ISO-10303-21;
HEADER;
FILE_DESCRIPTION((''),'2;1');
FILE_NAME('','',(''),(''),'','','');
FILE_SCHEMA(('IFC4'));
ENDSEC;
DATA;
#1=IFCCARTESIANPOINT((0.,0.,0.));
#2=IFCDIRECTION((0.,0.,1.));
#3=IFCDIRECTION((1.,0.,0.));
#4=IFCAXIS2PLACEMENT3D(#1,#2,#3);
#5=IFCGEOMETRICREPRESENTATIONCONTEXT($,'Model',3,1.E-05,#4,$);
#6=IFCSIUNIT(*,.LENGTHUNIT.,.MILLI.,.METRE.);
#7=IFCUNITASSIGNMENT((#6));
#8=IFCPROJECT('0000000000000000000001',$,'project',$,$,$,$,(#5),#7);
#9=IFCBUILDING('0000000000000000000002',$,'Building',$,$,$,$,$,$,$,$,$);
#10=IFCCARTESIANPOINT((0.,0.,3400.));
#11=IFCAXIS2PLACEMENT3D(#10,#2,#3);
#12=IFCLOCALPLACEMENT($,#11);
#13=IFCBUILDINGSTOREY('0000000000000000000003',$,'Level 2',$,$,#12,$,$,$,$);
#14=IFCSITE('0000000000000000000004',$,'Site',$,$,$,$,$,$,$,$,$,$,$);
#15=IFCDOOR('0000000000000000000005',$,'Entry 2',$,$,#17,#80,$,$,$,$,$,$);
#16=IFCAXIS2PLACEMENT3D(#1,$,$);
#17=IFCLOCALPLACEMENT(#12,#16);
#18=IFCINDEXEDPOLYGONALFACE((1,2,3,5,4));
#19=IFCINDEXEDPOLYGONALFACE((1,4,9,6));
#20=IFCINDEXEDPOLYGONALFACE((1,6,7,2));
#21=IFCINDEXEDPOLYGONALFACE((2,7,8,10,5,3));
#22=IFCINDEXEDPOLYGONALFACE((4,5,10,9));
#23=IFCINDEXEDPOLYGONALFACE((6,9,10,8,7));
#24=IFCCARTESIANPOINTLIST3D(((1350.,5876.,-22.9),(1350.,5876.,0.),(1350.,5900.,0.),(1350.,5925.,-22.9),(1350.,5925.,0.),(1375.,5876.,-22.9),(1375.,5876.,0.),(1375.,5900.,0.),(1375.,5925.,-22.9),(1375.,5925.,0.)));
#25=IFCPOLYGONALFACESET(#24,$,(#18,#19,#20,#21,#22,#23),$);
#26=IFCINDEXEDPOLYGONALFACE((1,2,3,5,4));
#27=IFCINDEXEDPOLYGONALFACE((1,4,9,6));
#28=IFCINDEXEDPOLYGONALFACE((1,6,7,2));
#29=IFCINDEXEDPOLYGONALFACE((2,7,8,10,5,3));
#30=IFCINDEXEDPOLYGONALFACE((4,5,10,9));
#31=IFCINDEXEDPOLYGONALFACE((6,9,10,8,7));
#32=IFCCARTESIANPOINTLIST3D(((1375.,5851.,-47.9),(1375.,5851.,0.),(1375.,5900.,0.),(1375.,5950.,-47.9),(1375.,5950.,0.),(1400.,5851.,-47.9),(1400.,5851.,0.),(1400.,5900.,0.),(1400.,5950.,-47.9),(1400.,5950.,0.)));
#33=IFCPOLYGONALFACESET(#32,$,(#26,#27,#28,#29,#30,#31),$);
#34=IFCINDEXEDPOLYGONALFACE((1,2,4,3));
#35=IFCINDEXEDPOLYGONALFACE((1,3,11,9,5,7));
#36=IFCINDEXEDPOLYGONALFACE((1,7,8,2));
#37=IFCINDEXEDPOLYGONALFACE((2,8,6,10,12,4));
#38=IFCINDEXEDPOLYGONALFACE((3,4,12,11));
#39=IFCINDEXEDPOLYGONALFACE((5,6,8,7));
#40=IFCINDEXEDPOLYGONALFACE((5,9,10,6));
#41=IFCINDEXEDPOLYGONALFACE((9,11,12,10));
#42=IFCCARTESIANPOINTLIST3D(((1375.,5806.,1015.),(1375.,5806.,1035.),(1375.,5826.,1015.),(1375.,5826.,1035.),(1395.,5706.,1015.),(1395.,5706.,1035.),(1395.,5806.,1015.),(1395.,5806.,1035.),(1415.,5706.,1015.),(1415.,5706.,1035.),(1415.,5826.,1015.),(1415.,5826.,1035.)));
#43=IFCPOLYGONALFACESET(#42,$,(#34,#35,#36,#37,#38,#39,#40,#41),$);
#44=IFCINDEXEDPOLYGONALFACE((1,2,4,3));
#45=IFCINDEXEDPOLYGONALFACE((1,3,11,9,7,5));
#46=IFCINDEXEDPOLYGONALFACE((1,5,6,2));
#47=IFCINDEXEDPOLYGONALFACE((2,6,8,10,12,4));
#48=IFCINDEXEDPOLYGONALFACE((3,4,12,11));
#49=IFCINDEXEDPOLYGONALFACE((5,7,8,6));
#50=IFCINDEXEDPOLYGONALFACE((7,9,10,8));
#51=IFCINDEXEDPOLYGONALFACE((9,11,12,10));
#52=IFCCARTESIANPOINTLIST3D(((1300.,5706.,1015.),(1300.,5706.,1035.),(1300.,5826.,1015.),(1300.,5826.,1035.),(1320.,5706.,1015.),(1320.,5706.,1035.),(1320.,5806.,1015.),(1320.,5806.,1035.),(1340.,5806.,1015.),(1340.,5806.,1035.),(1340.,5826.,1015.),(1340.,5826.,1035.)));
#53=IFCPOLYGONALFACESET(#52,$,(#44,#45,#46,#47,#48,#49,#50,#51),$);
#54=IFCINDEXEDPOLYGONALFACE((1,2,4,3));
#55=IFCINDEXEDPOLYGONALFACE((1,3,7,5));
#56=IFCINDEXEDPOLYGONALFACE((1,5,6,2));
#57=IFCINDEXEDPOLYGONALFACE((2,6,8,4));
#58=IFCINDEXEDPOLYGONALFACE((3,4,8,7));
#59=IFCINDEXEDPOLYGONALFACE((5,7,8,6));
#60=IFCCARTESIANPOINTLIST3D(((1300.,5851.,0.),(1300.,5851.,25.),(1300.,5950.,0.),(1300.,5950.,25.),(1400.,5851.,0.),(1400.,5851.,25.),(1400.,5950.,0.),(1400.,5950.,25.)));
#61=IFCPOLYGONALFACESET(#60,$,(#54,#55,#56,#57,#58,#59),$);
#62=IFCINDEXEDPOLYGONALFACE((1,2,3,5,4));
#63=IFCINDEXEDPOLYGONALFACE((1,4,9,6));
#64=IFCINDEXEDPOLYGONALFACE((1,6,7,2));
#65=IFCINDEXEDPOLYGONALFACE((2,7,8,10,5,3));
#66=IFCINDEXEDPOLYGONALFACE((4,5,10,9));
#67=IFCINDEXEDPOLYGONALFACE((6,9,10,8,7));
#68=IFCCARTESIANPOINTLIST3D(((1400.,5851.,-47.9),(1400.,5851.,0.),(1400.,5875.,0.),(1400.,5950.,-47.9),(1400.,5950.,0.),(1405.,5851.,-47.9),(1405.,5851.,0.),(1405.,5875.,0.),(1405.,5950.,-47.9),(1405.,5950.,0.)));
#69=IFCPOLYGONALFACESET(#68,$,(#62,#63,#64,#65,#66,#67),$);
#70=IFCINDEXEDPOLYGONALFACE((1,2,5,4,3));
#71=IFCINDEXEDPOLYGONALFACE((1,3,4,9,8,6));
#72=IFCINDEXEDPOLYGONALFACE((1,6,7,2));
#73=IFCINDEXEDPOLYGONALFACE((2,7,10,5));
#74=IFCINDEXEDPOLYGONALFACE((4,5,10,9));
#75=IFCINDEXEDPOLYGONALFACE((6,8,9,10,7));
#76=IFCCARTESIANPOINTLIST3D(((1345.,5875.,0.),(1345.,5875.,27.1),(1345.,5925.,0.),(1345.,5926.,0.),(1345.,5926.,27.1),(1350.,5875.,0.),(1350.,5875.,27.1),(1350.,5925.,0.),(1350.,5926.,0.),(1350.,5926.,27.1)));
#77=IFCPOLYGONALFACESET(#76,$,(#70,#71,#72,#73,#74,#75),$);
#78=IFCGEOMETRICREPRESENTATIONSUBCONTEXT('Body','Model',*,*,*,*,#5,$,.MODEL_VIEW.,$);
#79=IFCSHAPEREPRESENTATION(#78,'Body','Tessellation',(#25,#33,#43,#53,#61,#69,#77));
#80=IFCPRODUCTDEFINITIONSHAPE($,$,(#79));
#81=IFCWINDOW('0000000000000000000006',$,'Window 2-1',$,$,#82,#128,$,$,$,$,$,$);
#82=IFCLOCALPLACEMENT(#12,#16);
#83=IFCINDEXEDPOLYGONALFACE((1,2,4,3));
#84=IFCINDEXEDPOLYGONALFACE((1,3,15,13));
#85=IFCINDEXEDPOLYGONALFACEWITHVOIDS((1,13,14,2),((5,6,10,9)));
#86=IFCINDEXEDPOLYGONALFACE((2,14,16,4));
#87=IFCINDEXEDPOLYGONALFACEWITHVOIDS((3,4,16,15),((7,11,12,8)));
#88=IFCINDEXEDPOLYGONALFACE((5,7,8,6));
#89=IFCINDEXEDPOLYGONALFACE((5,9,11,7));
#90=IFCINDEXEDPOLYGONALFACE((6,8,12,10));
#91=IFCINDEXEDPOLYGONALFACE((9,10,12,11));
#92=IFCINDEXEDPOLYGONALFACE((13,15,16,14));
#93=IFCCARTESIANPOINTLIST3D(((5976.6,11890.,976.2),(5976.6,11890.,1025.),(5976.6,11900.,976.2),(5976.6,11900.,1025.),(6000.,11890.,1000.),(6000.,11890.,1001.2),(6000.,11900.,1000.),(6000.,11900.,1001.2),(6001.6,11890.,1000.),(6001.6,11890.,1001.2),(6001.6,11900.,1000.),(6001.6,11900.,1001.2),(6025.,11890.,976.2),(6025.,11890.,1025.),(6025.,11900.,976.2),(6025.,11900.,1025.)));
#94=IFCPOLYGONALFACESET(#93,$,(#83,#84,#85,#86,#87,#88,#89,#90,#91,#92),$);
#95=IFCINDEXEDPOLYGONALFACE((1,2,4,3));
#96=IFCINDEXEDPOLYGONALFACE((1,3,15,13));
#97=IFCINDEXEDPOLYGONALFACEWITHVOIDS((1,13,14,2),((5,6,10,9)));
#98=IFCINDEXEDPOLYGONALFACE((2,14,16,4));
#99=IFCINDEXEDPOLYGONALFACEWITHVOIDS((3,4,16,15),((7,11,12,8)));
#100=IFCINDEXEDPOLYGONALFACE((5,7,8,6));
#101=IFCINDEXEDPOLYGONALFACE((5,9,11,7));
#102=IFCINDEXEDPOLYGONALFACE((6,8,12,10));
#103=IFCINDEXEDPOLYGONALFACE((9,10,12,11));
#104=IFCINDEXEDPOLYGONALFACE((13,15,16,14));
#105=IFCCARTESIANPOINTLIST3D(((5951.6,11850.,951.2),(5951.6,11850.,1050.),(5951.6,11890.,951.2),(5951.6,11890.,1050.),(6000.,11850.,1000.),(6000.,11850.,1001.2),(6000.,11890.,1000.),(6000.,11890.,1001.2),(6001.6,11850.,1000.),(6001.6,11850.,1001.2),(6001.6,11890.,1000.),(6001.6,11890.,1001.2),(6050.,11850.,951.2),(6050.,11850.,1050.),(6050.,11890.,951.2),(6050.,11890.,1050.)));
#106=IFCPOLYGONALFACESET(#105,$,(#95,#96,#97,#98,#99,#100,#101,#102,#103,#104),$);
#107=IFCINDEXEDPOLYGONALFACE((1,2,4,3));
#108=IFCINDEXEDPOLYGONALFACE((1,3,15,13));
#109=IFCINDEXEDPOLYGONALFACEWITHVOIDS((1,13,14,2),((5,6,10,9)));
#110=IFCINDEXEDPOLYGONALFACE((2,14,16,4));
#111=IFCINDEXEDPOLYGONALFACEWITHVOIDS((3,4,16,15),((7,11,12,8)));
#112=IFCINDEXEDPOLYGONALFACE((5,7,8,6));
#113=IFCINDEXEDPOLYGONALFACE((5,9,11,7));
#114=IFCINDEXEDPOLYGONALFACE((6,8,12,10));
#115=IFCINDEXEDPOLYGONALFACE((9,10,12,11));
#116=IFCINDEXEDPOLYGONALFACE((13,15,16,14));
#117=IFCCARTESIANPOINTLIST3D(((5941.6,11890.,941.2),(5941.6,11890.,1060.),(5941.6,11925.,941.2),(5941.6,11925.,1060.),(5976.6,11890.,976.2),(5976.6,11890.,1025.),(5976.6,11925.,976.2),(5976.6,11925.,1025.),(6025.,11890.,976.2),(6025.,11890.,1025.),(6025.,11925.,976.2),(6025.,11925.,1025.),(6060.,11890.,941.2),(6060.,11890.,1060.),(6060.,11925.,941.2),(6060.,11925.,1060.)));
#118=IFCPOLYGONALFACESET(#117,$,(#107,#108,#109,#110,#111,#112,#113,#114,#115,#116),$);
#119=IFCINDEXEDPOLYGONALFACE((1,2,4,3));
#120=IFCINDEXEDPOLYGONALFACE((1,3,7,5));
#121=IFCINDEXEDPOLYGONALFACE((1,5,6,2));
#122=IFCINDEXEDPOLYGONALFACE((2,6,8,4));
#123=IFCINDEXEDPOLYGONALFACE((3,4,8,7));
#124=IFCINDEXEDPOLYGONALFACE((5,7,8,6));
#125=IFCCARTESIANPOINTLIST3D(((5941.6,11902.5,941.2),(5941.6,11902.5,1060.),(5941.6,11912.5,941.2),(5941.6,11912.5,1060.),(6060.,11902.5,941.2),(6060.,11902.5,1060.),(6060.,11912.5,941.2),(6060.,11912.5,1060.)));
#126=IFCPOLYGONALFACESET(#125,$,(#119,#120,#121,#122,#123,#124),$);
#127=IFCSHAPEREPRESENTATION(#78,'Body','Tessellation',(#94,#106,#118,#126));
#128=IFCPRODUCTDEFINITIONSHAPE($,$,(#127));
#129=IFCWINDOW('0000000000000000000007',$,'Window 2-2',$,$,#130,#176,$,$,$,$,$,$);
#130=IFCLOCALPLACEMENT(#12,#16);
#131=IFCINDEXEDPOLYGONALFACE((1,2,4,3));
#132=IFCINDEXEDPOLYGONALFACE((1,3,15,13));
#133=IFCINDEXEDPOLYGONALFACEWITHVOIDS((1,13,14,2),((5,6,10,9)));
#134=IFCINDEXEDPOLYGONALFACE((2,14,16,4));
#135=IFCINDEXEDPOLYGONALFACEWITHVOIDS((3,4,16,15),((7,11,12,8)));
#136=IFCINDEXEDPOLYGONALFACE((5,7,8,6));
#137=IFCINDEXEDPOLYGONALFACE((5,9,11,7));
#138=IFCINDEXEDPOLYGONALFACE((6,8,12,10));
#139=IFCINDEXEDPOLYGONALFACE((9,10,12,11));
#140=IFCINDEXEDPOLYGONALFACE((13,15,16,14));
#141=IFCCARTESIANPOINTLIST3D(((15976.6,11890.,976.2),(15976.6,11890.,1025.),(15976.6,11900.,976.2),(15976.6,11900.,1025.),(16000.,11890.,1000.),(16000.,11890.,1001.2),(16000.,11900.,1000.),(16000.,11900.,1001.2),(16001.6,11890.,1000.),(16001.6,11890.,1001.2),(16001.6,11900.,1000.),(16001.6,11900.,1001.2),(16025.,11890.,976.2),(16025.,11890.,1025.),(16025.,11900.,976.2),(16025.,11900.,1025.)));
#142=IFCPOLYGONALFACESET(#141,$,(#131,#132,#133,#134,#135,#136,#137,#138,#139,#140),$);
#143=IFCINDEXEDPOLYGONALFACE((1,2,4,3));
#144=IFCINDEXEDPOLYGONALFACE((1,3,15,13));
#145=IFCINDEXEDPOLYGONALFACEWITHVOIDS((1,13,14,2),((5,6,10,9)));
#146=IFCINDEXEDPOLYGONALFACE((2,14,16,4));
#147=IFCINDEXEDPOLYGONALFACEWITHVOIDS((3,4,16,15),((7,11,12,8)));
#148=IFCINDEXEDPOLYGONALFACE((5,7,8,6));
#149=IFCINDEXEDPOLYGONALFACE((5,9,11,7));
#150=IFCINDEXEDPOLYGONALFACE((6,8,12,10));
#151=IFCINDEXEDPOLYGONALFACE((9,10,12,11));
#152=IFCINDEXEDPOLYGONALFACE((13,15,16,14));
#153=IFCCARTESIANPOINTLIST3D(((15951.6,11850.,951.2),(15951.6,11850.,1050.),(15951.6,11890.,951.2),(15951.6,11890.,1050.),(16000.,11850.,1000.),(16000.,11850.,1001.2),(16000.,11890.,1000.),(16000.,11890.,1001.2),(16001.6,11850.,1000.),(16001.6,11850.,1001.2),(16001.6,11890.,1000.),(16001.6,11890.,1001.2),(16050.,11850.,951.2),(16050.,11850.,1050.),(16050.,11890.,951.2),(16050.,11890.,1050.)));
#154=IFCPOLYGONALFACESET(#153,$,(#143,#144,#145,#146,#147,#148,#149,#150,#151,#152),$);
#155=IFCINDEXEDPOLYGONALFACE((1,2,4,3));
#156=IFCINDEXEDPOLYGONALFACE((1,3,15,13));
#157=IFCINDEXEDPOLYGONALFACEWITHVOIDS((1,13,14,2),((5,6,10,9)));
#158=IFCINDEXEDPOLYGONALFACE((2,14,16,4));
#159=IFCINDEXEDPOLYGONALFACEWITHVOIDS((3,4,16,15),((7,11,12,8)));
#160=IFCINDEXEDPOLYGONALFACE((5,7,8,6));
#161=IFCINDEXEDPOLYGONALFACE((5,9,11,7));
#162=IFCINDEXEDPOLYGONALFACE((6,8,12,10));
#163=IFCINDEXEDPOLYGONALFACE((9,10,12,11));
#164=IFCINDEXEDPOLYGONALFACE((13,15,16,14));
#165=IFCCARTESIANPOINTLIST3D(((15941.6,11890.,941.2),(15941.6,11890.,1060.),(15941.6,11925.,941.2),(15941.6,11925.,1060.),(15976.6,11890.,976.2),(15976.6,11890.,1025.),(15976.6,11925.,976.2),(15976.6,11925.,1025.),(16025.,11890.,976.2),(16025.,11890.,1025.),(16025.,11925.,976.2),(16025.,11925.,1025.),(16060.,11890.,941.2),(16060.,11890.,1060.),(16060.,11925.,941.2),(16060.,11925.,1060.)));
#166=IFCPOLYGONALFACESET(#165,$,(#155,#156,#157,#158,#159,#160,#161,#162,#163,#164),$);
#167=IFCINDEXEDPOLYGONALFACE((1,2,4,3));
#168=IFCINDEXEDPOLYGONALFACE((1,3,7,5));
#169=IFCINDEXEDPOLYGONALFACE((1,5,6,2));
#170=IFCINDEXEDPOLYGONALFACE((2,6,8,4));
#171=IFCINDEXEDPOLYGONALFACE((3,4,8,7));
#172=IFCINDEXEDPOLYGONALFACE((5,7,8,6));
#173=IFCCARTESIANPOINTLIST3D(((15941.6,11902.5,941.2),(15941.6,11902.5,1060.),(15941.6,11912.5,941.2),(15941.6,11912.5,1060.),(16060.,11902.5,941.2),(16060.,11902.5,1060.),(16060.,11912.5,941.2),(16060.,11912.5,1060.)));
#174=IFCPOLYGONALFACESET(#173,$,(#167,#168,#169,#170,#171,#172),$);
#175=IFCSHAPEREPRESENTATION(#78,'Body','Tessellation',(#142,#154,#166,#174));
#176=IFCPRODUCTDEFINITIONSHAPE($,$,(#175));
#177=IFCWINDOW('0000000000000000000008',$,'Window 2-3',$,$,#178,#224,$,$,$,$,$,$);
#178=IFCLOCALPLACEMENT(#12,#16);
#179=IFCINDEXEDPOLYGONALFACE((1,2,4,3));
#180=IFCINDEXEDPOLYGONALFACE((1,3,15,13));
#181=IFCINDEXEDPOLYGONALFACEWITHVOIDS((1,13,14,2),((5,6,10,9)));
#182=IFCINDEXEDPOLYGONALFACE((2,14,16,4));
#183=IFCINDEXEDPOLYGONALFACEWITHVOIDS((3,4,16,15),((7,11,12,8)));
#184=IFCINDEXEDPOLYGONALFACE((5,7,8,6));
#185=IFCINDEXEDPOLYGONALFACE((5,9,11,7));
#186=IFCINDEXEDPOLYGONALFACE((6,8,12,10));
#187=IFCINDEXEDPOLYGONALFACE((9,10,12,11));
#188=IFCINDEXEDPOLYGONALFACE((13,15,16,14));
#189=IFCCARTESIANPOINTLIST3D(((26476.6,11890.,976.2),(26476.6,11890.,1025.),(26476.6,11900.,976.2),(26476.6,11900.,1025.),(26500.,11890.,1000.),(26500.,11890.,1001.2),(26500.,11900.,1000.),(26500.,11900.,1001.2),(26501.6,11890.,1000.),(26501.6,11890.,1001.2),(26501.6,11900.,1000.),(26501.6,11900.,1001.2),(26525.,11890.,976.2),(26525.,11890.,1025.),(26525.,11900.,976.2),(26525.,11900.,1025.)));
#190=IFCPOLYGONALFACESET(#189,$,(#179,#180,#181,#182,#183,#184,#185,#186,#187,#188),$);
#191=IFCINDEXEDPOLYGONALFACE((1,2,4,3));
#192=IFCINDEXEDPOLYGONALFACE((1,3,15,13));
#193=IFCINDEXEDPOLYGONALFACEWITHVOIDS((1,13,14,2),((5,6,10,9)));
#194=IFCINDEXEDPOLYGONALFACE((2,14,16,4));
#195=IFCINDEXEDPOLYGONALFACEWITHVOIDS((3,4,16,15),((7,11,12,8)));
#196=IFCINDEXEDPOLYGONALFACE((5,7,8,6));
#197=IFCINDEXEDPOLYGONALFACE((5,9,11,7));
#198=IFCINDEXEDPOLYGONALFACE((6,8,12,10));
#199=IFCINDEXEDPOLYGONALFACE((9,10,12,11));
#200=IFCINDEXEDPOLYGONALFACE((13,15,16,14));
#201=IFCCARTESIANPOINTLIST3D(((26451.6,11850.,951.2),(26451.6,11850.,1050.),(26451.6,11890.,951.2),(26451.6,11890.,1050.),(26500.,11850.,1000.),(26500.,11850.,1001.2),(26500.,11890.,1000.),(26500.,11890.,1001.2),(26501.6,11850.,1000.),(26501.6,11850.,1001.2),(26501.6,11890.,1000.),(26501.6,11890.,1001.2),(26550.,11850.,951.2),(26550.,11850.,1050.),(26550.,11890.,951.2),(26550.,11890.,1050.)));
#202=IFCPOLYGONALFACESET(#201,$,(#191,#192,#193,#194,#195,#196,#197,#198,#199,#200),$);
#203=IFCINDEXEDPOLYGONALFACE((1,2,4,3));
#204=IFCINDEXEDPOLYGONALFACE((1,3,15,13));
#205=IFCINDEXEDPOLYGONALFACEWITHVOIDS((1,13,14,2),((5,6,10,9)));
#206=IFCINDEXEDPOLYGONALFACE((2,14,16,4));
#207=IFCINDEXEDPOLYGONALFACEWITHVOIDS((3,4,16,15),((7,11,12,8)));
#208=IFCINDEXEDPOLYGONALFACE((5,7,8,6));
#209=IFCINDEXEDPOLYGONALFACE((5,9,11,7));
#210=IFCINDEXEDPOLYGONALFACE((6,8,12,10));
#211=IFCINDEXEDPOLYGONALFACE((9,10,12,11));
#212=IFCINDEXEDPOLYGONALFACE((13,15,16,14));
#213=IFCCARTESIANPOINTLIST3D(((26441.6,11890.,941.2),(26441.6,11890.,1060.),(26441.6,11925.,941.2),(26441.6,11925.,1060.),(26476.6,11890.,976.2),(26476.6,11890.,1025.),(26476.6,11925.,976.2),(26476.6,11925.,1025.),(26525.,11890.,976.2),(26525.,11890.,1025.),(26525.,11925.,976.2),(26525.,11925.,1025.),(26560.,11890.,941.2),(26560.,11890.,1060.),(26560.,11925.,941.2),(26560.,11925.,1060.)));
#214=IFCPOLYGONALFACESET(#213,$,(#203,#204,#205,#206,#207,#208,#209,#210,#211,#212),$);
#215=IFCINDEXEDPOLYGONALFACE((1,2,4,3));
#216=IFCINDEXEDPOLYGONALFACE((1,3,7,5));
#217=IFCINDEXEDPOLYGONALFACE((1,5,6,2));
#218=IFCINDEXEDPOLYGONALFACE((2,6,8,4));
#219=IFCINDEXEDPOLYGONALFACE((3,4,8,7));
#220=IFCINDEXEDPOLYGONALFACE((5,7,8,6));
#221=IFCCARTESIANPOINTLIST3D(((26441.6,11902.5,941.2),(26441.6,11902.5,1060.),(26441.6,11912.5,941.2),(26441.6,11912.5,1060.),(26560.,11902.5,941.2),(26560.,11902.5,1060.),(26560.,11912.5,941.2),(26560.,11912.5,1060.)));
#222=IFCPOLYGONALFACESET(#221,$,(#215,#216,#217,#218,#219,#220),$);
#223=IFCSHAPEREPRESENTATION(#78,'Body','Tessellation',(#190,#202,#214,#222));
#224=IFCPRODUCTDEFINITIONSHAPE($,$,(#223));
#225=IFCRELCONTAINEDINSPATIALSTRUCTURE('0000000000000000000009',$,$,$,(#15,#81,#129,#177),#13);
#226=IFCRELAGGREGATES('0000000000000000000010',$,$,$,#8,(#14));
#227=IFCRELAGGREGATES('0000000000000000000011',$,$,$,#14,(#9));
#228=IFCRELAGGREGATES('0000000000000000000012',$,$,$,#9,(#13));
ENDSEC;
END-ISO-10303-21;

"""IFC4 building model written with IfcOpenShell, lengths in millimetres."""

from ifc_helpers import new_model, si_unit, frame, origin_with_axes, place, context, subcontext, project, spatial, line, indexed_curve, outline, extrude, element, save


model = new_model("IFC4")

# Units and contexts
model_context = context("Model", 3, precision=1e-05, world=origin_with_axes())
body_context = subcontext(model_context, "Body", "Model", "MODEL_VIEW")
ifc_project = project(units=[si_unit("LENGTHUNIT", "METRE", prefix="MILLI")], contexts=[model_context])

# Site, building, storey
site = spatial("IfcSite", under=ifc_project, Name="Site")
building = spatial("IfcBuilding", under=site, Name="Building")
storey_placement = place(None, frame((0.0, 0.0, 3400.0), z_axis=(0.0, 0.0, 1.0), x_axis=(1.0, 0.0, 0.0)))
storey = spatial("IfcBuildingStorey", under=building, at=storey_placement, Name="Level 2")

# Door
door_1_placement = place(storey_placement, frame((1400.0, 5900.0, 0.0), z_axis=(0.0, 0.0, 1.0), x_axis=(0.0, 1.0, 0.0)))
element("IfcDoor", 1, at=door_1_placement, inside=storey, Name="Entry 2", context=body_context, shape_type="SweptSolid", body=[
    extrude(outline(indexed_curve([(0.0, 0.0), (0.0, 2.1), (1.0, 2.1), (1.0, 0.0), (-24.0, 0.0), (-24.0, -22.9), (25.0, -22.9), (25.0, 0.0)], segments=[line(1, 2, 3, 4, 5, 6, 7, 8, 1)])), frame((0.0, 25.0, 0.0), z_axis=(0.0, -1.0, 0.0), x_axis=(1.0, 0.0, 0.0)), (0.0, 0.0, -1.0), 25.0),
    extrude(outline(indexed_curve([(0.0, 0.0), (0.0, 2.1), (1.0, 2.1), (1.0, 0.0), (-49.0, 0.0), (-49.0, -47.9), (50.0, -47.9), (50.0, 0.0)], segments=[line(1, 2, 3, 4, 5, 6, 7, 8, 1)])), frame((0.0, 0.0, 0.0), z_axis=(0.0, -1.0, 0.0), x_axis=(1.0, 0.0, 0.0)), (0.0, 0.0, -1.0), 25.0),
    extrude(outline(indexed_curve([(0.0, 0.0), (-49.0, 0.0), (-49.0, 35.0), (0.0, 35.0)], segments=[line(1, 2, 3, 4, 1)])), frame((25.0, 25.0, 25.0), z_axis=(0.0, 0.0, 1.0), x_axis=(1.0, 0.0, 0.0)), (0.0, 0.0, 1.0), -47.9),
    extrude(outline(indexed_curve([(0.0, 0.0), (0.0, -40.0), (-120.0, -40.0), (-120.0, -20.0), (-20.0, -20.0), (-20.0, 0.0)], segments=[line(1, 2, 3, 4, 5, 6, 1)])), frame((-74.0, 25.0, 1015.0), z_axis=(0.0, 0.0, 1.0), x_axis=(1.0, 0.0, 0.0)), (0.0, 0.0, 1.0), 20.0),
    extrude(outline(indexed_curve([(0.0, 0.0), (0.0, 40.0), (-120.0, 40.0), (-120.0, 20.0), (-20.0, 20.0), (-20.0, 0.0)], segments=[line(1, 2, 3, 4, 5, 6, 1)])), frame((-74.0, 60.0, 1015.0), z_axis=(0.0, 0.0, 1.0), x_axis=(1.0, 0.0, 0.0)), (0.0, 0.0, 1.0), 20.0),
    extrude(outline(indexed_curve([(0.0, 0.0), (-99.0, 0.0), (-99.0, 100.0), (0.0, 100.0)], segments=[line(1, 2, 3, 4, 1)])), frame((50.0, 0.0, 0.0), z_axis=(0.0, 0.0, 1.0), x_axis=(1.0, 0.0, 0.0)), (0.0, 0.0, 1.0), 25.0),
    extrude(outline(indexed_curve([(0.0, 0.0), (0.0, 27.1), (51.0, 27.1), (51.0, 0.0), (-24.0, 0.0), (-24.0, -47.9), (75.0, -47.9), (75.0, 0.0)], segments=[line(1, 2, 3, 4, 5, 6, 7, 8, 1)])), frame((-25.0, -5.0, 0.0), z_axis=(0.0, -1.0, 0.0), x_axis=(1.0, 0.0, 0.0)), (0.0, 0.0, -1.0), 5.0),
    extrude(outline(indexed_curve([(0.0, 0.0), (0.0, 27.1), (51.0, 27.1), (51.0, 0.0), (1.0, 0.0), (1.0, -22.9), (50.0, -22.9), (50.0, 0.0)], segments=[line(1, 2, 3, 4, 5, 6, 7, 8, 1)])), frame((-25.0, 50.0, 0.0), z_axis=(0.0, -1.0, 0.0), x_axis=(1.0, 0.0, 0.0)), (0.0, 0.0, -1.0), 5.0),
])

# Windows
for number, where, z_axis, x_axis, name in (
    (2, (6000.0, 11800.0, 1000.0), (0.0, 0.0, 1.0), (1.0, 0.0, 0.0), "Window 2-1"),
    (3, (16000.0, 11800.0, 1000.0), (0.0, 0.0, 1.0), (1.0, 0.0, 0.0), "Window 2-2"),
    (4, (26500.0, 11800.0, 1000.0), (0.0, 0.0, 1.0), (1.0, 0.0, 0.0), "Window 2-3"),
):
    element("IfcWindow", number, at=place(storey_placement, frame(where, z_axis=z_axis, x_axis=x_axis)), inside=storey, Name=name, context=body_context, shape_type="SweptSolid", body=[
        extrude(outline(indexed_curve([(0.0, 0.0), (1.6, 0.0), (1.6, 1.2), (0.0, 1.2)], segments=[line(1, 2, 3, 4, 1)]), holes=[indexed_curve([(25.0, 25.0), (-23.4, 25.0), (-23.4, -23.8), (25.0, -23.8)], segments=[line(1, 2, 3, 4, 1)])]), frame((0.0, 90.0, 0.0), z_axis=(0.0, -1.0, 0.0), x_axis=(1.0, 0.0, 0.0)), (0.0, 0.0, -1.0), 10.0),
        extrude(outline(indexed_curve([(0.0, 0.0), (1.6, 0.0), (1.6, 1.2), (0.0, 1.2)], segments=[line(1, 2, 3, 4, 1)]), holes=[indexed_curve([(50.0, 50.0), (-48.4, 50.0), (-48.4, -48.8), (50.0, -48.8)], segments=[line(1, 2, 3, 4, 1)])]), frame((0.0, 50.0, 0.0), z_axis=(0.0, -1.0, 0.0), x_axis=(1.0, 0.0, 0.0)), (0.0, 0.0, -1.0), 40.0),
        extrude(outline(indexed_curve([(0.0, 0.0), (-48.4, 0.0), (-48.4, -48.8), (0.0, -48.8)], segments=[line(1, 2, 3, 4, 1)]), holes=[indexed_curve([(35.0, 35.0), (-83.4, 35.0), (-83.4, -83.8), (35.0, -83.8)], segments=[line(1, 2, 3, 4, 1)])]), frame((25.0, 90.0, 25.0), z_axis=(0.0, -1.0, 0.0), x_axis=(1.0, 0.0, 0.0)), (0.0, 0.0, -1.0), 35.0),
        extrude(outline(indexed_curve([(35.0, 35.0), (-83.4, 35.0), (-83.4, -83.8), (35.0, -83.8)], segments=[line(1, 2, 3, 4, 1)])), frame((25.0, 102.5, 25.0), z_axis=(0.0, -1.0, 0.0), x_axis=(1.0, 0.0, 0.0)), (0.0, 0.0, -1.0), 10.0),
    ])

save(model, "model.ifc")
